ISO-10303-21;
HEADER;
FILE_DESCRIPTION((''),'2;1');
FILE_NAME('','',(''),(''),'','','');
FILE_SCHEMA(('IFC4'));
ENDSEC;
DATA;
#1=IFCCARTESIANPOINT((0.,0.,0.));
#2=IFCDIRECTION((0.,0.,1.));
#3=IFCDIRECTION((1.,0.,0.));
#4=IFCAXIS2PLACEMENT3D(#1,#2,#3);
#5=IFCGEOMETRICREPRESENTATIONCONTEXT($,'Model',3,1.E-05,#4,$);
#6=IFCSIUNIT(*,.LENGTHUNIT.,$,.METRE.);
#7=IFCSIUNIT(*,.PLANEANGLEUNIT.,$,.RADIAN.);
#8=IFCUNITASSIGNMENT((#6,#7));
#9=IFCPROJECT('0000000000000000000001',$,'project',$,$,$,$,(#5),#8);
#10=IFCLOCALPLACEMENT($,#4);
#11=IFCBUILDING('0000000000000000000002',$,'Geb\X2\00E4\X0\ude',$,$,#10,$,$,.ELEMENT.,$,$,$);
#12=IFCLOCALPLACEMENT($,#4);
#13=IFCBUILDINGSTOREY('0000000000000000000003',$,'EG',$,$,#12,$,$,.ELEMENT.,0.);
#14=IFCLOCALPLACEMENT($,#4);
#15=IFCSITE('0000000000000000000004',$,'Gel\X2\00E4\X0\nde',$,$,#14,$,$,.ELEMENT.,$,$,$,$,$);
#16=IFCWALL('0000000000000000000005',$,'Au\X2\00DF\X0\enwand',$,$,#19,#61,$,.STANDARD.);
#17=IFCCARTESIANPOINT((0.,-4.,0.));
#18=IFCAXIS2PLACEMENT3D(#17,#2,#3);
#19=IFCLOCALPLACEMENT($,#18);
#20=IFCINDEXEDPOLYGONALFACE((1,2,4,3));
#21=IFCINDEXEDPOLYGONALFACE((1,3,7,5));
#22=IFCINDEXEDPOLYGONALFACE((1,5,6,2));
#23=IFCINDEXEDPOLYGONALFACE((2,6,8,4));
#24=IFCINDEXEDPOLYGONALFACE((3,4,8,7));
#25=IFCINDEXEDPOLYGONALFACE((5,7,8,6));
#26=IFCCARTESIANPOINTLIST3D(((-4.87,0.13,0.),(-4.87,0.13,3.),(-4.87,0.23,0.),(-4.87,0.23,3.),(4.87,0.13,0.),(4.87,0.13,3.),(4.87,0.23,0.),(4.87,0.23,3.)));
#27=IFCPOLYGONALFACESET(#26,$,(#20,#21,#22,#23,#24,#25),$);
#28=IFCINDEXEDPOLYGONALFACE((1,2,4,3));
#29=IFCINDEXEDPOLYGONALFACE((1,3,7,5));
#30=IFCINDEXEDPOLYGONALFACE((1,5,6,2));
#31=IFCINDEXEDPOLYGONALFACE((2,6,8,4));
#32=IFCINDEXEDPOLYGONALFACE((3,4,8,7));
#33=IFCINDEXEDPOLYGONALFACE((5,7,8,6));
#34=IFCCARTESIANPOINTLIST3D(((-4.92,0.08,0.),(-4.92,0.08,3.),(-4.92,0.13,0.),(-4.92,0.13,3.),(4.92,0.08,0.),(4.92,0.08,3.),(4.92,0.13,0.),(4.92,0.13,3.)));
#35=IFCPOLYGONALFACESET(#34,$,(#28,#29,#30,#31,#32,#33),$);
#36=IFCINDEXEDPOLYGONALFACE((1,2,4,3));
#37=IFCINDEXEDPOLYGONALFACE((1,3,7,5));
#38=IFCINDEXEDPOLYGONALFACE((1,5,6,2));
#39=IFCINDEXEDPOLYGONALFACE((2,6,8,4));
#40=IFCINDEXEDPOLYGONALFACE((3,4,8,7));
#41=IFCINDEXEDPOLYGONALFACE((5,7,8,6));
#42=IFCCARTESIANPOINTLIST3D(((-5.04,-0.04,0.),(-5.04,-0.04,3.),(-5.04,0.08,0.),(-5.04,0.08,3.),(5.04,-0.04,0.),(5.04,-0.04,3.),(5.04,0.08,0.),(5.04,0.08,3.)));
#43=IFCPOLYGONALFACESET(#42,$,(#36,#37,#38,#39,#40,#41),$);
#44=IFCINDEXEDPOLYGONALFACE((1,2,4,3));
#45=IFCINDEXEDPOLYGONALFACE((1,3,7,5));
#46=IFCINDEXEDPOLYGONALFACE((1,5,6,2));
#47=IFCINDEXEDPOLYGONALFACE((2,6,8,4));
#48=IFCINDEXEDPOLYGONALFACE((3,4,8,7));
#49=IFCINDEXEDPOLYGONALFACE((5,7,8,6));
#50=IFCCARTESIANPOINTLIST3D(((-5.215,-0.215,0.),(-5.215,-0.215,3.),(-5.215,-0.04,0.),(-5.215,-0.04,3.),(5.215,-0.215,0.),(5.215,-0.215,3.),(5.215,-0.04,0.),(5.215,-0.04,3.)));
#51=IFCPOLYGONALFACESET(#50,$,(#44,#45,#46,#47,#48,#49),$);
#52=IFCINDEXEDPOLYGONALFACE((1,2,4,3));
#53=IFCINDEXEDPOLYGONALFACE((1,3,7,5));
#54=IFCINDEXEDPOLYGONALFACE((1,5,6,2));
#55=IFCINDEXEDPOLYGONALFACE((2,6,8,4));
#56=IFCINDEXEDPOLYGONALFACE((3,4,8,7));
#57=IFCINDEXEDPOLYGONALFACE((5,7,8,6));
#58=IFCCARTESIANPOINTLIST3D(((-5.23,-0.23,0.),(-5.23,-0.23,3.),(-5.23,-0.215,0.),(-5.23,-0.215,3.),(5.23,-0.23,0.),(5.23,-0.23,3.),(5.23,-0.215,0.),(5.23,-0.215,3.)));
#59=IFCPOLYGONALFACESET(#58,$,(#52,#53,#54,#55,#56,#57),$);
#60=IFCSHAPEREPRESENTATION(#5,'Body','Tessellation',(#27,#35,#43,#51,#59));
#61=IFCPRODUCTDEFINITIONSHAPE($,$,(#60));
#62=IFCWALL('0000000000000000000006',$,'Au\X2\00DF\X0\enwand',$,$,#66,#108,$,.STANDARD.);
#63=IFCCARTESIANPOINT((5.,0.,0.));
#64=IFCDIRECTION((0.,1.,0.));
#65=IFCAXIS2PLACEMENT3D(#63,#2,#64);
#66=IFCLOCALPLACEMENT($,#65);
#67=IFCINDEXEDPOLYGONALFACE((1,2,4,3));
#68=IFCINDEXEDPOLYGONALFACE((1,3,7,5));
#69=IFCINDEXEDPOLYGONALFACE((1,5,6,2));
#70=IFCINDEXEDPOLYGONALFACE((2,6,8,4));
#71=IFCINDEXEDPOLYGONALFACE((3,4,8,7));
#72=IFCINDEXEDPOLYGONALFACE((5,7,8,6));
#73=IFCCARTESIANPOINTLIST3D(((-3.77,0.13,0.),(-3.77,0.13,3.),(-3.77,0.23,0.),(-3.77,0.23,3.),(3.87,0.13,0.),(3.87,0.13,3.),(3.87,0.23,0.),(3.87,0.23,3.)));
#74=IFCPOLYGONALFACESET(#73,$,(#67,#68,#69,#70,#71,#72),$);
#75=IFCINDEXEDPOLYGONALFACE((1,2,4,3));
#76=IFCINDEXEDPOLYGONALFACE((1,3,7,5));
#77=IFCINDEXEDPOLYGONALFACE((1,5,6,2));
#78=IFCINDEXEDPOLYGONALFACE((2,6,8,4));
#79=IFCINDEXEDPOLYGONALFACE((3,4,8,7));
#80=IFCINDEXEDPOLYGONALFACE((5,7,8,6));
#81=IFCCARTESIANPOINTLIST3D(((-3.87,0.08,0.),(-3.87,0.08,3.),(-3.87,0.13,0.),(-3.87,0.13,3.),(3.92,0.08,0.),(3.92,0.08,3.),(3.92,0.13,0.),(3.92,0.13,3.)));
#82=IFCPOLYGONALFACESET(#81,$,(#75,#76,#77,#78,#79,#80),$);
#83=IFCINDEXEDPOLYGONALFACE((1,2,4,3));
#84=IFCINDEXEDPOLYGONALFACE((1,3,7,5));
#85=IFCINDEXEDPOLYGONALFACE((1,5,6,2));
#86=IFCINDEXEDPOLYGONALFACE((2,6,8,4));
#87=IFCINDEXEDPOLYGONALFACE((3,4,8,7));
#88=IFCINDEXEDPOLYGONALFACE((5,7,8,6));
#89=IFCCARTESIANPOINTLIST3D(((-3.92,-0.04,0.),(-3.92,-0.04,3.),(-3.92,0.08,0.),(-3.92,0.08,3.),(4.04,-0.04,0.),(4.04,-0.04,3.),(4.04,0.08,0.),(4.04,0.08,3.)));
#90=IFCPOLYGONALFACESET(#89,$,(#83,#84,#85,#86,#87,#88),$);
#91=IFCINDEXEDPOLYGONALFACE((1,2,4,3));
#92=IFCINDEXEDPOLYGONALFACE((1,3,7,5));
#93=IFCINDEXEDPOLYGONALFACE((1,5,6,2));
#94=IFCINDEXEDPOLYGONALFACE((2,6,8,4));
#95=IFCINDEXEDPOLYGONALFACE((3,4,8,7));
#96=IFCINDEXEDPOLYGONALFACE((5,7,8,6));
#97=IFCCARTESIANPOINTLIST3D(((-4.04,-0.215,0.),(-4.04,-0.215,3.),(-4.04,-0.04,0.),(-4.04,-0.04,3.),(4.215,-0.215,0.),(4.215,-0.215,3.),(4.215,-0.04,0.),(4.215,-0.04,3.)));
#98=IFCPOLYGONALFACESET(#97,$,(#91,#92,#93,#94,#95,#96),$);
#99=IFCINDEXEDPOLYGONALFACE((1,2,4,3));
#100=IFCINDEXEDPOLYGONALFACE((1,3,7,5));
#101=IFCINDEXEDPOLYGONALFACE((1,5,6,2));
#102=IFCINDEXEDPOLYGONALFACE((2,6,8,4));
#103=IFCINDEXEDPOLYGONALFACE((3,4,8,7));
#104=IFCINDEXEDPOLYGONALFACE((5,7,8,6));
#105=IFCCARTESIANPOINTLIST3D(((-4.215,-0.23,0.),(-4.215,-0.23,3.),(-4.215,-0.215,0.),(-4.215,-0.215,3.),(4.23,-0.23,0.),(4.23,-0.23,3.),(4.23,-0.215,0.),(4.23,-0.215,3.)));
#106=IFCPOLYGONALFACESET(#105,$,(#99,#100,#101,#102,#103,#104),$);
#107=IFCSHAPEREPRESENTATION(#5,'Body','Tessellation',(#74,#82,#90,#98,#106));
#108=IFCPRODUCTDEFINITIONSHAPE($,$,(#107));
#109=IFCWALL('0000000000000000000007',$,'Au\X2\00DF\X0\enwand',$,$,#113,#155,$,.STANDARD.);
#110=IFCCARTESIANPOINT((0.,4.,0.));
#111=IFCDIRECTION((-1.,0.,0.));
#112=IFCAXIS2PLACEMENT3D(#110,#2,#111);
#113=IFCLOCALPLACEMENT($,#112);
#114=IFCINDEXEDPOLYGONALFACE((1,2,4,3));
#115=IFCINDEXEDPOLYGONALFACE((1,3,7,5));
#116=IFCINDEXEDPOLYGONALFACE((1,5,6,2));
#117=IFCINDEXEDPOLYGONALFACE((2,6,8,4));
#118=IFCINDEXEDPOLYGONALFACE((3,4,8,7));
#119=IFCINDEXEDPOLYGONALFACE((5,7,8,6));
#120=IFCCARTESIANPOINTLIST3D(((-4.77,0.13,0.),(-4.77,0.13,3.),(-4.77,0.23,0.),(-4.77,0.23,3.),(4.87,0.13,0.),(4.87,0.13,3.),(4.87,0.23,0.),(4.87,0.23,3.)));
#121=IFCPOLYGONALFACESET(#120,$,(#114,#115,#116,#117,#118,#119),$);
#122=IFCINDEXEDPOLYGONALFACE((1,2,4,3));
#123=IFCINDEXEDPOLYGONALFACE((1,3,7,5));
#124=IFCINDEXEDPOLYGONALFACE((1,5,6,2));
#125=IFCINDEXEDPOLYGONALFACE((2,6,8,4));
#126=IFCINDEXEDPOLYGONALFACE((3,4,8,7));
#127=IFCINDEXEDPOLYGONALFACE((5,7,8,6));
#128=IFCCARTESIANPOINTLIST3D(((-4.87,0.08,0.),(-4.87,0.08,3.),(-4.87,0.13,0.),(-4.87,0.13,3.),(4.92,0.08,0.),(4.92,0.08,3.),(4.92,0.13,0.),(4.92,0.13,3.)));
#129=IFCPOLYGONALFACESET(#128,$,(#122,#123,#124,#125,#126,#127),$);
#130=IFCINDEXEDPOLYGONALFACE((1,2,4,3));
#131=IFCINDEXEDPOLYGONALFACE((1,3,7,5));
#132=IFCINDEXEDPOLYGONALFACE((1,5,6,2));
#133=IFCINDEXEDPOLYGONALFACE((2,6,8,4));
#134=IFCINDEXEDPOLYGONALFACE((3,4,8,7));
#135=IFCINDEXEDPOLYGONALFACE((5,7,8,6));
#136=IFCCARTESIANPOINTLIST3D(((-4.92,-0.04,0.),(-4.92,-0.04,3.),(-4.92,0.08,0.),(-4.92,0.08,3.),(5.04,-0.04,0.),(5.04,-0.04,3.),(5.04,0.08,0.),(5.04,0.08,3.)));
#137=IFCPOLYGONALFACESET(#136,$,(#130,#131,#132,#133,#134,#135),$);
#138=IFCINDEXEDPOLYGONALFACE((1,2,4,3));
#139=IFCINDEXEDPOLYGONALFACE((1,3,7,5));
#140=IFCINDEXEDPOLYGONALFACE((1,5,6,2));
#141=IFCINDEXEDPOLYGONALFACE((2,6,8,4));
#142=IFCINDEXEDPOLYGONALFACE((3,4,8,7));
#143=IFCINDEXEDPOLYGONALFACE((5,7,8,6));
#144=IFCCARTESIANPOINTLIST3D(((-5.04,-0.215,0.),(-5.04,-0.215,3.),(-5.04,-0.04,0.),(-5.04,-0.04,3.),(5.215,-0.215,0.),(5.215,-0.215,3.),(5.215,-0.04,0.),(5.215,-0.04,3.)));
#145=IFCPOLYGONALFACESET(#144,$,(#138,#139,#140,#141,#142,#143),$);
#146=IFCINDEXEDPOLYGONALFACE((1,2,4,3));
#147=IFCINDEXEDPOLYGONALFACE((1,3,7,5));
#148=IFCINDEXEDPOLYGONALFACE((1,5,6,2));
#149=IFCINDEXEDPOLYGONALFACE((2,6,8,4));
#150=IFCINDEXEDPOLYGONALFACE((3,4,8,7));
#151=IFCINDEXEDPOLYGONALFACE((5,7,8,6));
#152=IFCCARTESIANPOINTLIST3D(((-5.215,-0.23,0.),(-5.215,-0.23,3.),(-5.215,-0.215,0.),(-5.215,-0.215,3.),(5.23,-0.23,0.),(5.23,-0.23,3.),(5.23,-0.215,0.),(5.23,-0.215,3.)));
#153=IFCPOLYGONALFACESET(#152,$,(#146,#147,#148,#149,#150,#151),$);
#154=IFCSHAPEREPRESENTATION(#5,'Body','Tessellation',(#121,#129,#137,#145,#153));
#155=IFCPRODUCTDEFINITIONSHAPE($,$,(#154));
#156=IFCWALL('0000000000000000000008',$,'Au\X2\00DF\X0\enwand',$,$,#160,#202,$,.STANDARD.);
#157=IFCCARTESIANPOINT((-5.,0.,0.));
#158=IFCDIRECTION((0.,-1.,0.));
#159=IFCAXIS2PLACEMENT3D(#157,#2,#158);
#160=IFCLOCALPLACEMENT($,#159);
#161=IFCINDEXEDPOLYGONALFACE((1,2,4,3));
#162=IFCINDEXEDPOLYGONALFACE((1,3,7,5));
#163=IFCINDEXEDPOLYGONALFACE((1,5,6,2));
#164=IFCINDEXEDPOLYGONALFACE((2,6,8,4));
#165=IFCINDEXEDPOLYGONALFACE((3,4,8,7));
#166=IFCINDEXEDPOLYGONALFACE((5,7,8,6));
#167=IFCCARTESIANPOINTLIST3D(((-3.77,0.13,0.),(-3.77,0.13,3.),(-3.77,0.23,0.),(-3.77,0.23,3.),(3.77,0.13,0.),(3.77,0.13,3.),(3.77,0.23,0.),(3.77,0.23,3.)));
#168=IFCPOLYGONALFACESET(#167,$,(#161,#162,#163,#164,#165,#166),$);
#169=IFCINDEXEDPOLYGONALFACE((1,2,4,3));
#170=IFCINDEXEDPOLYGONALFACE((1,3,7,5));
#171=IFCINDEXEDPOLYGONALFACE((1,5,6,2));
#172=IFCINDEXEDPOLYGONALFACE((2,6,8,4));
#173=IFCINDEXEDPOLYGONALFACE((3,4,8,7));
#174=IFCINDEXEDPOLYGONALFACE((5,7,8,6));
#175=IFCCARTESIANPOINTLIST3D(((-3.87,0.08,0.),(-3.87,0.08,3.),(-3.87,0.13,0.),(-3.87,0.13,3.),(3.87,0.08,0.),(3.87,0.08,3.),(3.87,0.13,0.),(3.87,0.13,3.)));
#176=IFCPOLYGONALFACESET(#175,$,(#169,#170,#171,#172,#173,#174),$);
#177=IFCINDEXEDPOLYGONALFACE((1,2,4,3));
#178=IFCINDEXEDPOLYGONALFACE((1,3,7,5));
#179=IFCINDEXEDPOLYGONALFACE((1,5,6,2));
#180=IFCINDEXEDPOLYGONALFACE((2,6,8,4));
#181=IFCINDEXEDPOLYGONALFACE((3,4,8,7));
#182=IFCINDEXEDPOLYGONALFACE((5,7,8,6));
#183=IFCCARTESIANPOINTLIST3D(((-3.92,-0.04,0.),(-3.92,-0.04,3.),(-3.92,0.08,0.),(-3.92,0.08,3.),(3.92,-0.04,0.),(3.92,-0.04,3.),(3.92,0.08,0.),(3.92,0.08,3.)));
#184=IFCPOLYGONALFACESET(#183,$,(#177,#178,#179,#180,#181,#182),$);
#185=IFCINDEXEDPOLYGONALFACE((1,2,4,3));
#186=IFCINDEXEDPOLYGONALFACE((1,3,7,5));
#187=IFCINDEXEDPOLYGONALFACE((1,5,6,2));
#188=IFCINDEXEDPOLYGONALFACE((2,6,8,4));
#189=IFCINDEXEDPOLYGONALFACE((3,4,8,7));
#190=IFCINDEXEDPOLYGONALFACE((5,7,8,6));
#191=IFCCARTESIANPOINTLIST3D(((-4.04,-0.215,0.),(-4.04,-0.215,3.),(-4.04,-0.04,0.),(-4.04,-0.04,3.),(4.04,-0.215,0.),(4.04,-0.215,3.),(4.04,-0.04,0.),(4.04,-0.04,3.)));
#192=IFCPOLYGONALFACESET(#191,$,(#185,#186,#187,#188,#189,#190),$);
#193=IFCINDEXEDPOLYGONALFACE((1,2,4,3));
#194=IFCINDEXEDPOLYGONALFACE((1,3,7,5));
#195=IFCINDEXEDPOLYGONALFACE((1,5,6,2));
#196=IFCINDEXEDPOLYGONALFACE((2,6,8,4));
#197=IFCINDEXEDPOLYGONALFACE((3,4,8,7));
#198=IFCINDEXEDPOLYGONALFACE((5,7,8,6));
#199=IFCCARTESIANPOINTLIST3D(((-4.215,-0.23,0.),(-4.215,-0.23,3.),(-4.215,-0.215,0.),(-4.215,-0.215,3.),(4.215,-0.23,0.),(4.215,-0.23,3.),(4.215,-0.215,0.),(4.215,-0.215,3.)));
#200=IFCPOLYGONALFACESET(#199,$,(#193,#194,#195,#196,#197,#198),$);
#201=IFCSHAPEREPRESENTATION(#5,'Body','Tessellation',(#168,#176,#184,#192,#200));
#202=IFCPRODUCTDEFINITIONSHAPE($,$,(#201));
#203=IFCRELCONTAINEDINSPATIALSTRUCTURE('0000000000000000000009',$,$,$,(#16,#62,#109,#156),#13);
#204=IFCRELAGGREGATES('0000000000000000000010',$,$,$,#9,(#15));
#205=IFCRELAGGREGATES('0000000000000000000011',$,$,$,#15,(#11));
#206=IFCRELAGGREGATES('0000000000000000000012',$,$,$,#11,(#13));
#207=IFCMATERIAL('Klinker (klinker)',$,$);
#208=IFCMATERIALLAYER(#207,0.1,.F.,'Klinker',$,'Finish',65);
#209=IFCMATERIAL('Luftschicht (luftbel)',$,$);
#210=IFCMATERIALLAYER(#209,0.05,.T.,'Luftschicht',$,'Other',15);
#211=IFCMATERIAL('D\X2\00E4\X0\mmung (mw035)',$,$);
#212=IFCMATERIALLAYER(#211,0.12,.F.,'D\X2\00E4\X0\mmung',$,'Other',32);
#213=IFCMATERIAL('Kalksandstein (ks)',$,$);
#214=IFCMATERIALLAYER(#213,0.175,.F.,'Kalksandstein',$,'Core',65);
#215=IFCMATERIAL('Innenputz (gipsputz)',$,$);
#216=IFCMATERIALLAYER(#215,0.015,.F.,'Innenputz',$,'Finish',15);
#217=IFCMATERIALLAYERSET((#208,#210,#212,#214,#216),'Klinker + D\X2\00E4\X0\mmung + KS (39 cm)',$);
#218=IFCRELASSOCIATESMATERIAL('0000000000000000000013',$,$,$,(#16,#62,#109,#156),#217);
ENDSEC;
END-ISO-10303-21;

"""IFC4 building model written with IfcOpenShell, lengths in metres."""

from ifc_helpers import new_model, si_unit, frame, origin_with_axes, place, context, project, spatial, polyline, outline, extrude, material, layer, layer_set, layer_usage, element, save


model = new_model("IFC4")

# Units and contexts
model_context = context("Model", 3, precision=1e-05, world=origin_with_axes())
ifc_project = project(units=[si_unit("LENGTHUNIT", "METRE"), si_unit("PLANEANGLEUNIT", "RADIAN")], contexts=[model_context])

# Site, building, storey
site_placement = place(None, origin_with_axes())
site = spatial("IfcSite", under=ifc_project, at=site_placement, Name="Gelände", CompositionType="ELEMENT")
building_placement = place(None, origin_with_axes())
building = spatial("IfcBuilding", under=site, at=building_placement, Name="Gebäude", CompositionType="ELEMENT")
storey_placement = place(None, origin_with_axes())
storey = spatial("IfcBuildingStorey", under=building, at=storey_placement, Name="EG", CompositionType="ELEMENT", Elevation=0.0)

# Walls
ifc_material_1 = material(Name="Klinker (klinker)")
ifc_layer_1 = layer(ifc_material_1, 0.1, ventilated=False, Name="Klinker", Category="Finish", Priority=65)
ifc_material_2 = material(Name="Luftschicht (luftbel)")
ifc_layer_2 = layer(ifc_material_2, 0.05, ventilated=True, Name="Luftschicht", Category="Other", Priority=15)
ifc_material_3 = material(Name="Dämmung (mw035)")
ifc_layer_3 = layer(ifc_material_3, 0.12, ventilated=False, Name="Dämmung", Category="Other", Priority=32)
ifc_material_4 = material(Name="Kalksandstein (ks)")
ifc_layer_4 = layer(ifc_material_4, 0.175, ventilated=False, Name="Kalksandstein", Category="Core", Priority=65)
ifc_material_5 = material(Name="Innenputz (gipsputz)")
ifc_layer_5 = layer(ifc_material_5, 0.015, ventilated=False, Name="Innenputz", Category="Finish", Priority=15)
ifc_layer_set_1 = layer_set([ifc_layer_1, ifc_layer_2, ifc_layer_3, ifc_layer_4, ifc_layer_5], Name="Klinker + Dämmung + KS (39 cm)")
ifc_layer_usage_1 = layer_usage(ifc_layer_set_1, "AXIS2", "NEGATIVE", 0.23)
wall_1_placement = place(None, frame((0.0, -4.0, 0.0), z_axis=(0.0, 0.0, 1.0), x_axis=(1.0, 0.0, 0.0)))
element("IfcWall", 1, at=wall_1_placement, inside=storey, material=ifc_layer_usage_1, Name="Außenwand", PredefinedType="STANDARD", context=model_context, shape_type="SweptSolid", body=[
    extrude(outline(polyline([(-4.87, 0.13), (4.87, 0.13), (4.87, 0.23), (-4.87, 0.23), (-4.87, 0.13)])), origin_with_axes(), (0.0, 0.0, 1.0), 3.0),
    extrude(outline(polyline([(-4.92, 0.08), (4.92, 0.08), (4.92, 0.13), (-4.92, 0.13), (-4.92, 0.08)])), origin_with_axes(), (0.0, 0.0, 1.0), 3.0),
    extrude(outline(polyline([(-5.04, -0.04), (5.04, -0.04), (5.04, 0.08), (-5.04, 0.08), (-5.04, -0.04)])), origin_with_axes(), (0.0, 0.0, 1.0), 3.0),
    extrude(outline(polyline([(-5.215, -0.215), (5.215, -0.215), (5.215, -0.04), (-5.215, -0.04), (-5.215, -0.215)])), origin_with_axes(), (0.0, 0.0, 1.0), 3.0),
    extrude(outline(polyline([(-5.23, -0.23), (5.23, -0.23), (5.23, -0.215), (-5.23, -0.215), (-5.23, -0.23)])), origin_with_axes(), (0.0, 0.0, 1.0), 3.0),
])
ifc_layer_usage_2 = layer_usage(ifc_layer_set_1, "AXIS2", "NEGATIVE", 0.23)
wall_2_placement = place(None, frame((5.0, 0.0, 0.0), z_axis=(0.0, 0.0, 1.0), x_axis=(0.0, 1.0, 0.0)))
element("IfcWall", 2, at=wall_2_placement, inside=storey, material=ifc_layer_usage_2, Name="Außenwand", PredefinedType="STANDARD", context=model_context, shape_type="SweptSolid", body=[
    extrude(outline(polyline([(-3.77, 0.13), (3.87, 0.13), (3.87, 0.23), (-3.77, 0.23), (-3.77, 0.13)])), origin_with_axes(), (0.0, 0.0, 1.0), 3.0),
    extrude(outline(polyline([(-3.87, 0.08), (3.92, 0.08), (3.92, 0.13), (-3.87, 0.13), (-3.87, 0.08)])), origin_with_axes(), (0.0, 0.0, 1.0), 3.0),
    extrude(outline(polyline([(-3.92, -0.04), (4.04, -0.04), (4.04, 0.08), (-3.92, 0.08), (-3.92, -0.04)])), origin_with_axes(), (0.0, 0.0, 1.0), 3.0),
    extrude(outline(polyline([(-4.04, -0.215), (4.215, -0.215), (4.215, -0.04), (-4.04, -0.04), (-4.04, -0.215)])), origin_with_axes(), (0.0, 0.0, 1.0), 3.0),
    extrude(outline(polyline([(-4.215, -0.23), (4.23, -0.23), (4.23, -0.215), (-4.215, -0.215), (-4.215, -0.23)])), origin_with_axes(), (0.0, 0.0, 1.0), 3.0),
])
ifc_layer_usage_3 = layer_usage(ifc_layer_set_1, "AXIS2", "NEGATIVE", 0.23)
wall_3_placement = place(None, frame((0.0, 4.0, 0.0), z_axis=(0.0, 0.0, 1.0), x_axis=(-1.0, 0.0, 0.0)))
element("IfcWall", 3, at=wall_3_placement, inside=storey, material=ifc_layer_usage_3, Name="Außenwand", PredefinedType="STANDARD", context=model_context, shape_type="SweptSolid", body=[
    extrude(outline(polyline([(-4.77, 0.13), (4.87, 0.13), (4.87, 0.23), (-4.77, 0.23), (-4.77, 0.13)])), origin_with_axes(), (0.0, 0.0, 1.0), 3.0),
    extrude(outline(polyline([(-4.87, 0.08), (4.92, 0.08), (4.92, 0.13), (-4.87, 0.13), (-4.87, 0.08)])), origin_with_axes(), (0.0, 0.0, 1.0), 3.0),
    extrude(outline(polyline([(-4.92, -0.04), (5.04, -0.04), (5.04, 0.08), (-4.92, 0.08), (-4.92, -0.04)])), origin_with_axes(), (0.0, 0.0, 1.0), 3.0),
    extrude(outline(polyline([(-5.04, -0.215), (5.215, -0.215), (5.215, -0.04), (-5.04, -0.04), (-5.04, -0.215)])), origin_with_axes(), (0.0, 0.0, 1.0), 3.0),
    extrude(outline(polyline([(-5.215, -0.23), (5.23, -0.23), (5.23, -0.215), (-5.215, -0.215), (-5.215, -0.23)])), origin_with_axes(), (0.0, 0.0, 1.0), 3.0),
])
ifc_layer_usage_4 = layer_usage(ifc_layer_set_1, "AXIS2", "NEGATIVE", 0.23)
wall_4_placement = place(None, frame((-5.0, 0.0, 0.0), z_axis=(0.0, 0.0, 1.0), x_axis=(0.0, -1.0, 0.0)))
element("IfcWall", 4, at=wall_4_placement, inside=storey, material=ifc_layer_usage_4, Name="Außenwand", PredefinedType="STANDARD", context=model_context, shape_type="SweptSolid", body=[
    extrude(outline(polyline([(-3.77, 0.13), (3.77, 0.13), (3.77, 0.23), (-3.77, 0.23), (-3.77, 0.13)])), origin_with_axes(), (0.0, 0.0, 1.0), 3.0),
    extrude(outline(polyline([(-3.87, 0.08), (3.87, 0.08), (3.87, 0.13), (-3.87, 0.13), (-3.87, 0.08)])), origin_with_axes(), (0.0, 0.0, 1.0), 3.0),
    extrude(outline(polyline([(-3.92, -0.04), (3.92, -0.04), (3.92, 0.08), (-3.92, 0.08), (-3.92, -0.04)])), origin_with_axes(), (0.0, 0.0, 1.0), 3.0),
    extrude(outline(polyline([(-4.04, -0.215), (4.04, -0.215), (4.04, -0.04), (-4.04, -0.04), (-4.04, -0.215)])), origin_with_axes(), (0.0, 0.0, 1.0), 3.0),
    extrude(outline(polyline([(-4.215, -0.23), (4.215, -0.23), (4.215, -0.215), (-4.215, -0.215), (-4.215, -0.23)])), origin_with_axes(), (0.0, 0.0, 1.0), 3.0),
])

save(model, "model.ifc")
